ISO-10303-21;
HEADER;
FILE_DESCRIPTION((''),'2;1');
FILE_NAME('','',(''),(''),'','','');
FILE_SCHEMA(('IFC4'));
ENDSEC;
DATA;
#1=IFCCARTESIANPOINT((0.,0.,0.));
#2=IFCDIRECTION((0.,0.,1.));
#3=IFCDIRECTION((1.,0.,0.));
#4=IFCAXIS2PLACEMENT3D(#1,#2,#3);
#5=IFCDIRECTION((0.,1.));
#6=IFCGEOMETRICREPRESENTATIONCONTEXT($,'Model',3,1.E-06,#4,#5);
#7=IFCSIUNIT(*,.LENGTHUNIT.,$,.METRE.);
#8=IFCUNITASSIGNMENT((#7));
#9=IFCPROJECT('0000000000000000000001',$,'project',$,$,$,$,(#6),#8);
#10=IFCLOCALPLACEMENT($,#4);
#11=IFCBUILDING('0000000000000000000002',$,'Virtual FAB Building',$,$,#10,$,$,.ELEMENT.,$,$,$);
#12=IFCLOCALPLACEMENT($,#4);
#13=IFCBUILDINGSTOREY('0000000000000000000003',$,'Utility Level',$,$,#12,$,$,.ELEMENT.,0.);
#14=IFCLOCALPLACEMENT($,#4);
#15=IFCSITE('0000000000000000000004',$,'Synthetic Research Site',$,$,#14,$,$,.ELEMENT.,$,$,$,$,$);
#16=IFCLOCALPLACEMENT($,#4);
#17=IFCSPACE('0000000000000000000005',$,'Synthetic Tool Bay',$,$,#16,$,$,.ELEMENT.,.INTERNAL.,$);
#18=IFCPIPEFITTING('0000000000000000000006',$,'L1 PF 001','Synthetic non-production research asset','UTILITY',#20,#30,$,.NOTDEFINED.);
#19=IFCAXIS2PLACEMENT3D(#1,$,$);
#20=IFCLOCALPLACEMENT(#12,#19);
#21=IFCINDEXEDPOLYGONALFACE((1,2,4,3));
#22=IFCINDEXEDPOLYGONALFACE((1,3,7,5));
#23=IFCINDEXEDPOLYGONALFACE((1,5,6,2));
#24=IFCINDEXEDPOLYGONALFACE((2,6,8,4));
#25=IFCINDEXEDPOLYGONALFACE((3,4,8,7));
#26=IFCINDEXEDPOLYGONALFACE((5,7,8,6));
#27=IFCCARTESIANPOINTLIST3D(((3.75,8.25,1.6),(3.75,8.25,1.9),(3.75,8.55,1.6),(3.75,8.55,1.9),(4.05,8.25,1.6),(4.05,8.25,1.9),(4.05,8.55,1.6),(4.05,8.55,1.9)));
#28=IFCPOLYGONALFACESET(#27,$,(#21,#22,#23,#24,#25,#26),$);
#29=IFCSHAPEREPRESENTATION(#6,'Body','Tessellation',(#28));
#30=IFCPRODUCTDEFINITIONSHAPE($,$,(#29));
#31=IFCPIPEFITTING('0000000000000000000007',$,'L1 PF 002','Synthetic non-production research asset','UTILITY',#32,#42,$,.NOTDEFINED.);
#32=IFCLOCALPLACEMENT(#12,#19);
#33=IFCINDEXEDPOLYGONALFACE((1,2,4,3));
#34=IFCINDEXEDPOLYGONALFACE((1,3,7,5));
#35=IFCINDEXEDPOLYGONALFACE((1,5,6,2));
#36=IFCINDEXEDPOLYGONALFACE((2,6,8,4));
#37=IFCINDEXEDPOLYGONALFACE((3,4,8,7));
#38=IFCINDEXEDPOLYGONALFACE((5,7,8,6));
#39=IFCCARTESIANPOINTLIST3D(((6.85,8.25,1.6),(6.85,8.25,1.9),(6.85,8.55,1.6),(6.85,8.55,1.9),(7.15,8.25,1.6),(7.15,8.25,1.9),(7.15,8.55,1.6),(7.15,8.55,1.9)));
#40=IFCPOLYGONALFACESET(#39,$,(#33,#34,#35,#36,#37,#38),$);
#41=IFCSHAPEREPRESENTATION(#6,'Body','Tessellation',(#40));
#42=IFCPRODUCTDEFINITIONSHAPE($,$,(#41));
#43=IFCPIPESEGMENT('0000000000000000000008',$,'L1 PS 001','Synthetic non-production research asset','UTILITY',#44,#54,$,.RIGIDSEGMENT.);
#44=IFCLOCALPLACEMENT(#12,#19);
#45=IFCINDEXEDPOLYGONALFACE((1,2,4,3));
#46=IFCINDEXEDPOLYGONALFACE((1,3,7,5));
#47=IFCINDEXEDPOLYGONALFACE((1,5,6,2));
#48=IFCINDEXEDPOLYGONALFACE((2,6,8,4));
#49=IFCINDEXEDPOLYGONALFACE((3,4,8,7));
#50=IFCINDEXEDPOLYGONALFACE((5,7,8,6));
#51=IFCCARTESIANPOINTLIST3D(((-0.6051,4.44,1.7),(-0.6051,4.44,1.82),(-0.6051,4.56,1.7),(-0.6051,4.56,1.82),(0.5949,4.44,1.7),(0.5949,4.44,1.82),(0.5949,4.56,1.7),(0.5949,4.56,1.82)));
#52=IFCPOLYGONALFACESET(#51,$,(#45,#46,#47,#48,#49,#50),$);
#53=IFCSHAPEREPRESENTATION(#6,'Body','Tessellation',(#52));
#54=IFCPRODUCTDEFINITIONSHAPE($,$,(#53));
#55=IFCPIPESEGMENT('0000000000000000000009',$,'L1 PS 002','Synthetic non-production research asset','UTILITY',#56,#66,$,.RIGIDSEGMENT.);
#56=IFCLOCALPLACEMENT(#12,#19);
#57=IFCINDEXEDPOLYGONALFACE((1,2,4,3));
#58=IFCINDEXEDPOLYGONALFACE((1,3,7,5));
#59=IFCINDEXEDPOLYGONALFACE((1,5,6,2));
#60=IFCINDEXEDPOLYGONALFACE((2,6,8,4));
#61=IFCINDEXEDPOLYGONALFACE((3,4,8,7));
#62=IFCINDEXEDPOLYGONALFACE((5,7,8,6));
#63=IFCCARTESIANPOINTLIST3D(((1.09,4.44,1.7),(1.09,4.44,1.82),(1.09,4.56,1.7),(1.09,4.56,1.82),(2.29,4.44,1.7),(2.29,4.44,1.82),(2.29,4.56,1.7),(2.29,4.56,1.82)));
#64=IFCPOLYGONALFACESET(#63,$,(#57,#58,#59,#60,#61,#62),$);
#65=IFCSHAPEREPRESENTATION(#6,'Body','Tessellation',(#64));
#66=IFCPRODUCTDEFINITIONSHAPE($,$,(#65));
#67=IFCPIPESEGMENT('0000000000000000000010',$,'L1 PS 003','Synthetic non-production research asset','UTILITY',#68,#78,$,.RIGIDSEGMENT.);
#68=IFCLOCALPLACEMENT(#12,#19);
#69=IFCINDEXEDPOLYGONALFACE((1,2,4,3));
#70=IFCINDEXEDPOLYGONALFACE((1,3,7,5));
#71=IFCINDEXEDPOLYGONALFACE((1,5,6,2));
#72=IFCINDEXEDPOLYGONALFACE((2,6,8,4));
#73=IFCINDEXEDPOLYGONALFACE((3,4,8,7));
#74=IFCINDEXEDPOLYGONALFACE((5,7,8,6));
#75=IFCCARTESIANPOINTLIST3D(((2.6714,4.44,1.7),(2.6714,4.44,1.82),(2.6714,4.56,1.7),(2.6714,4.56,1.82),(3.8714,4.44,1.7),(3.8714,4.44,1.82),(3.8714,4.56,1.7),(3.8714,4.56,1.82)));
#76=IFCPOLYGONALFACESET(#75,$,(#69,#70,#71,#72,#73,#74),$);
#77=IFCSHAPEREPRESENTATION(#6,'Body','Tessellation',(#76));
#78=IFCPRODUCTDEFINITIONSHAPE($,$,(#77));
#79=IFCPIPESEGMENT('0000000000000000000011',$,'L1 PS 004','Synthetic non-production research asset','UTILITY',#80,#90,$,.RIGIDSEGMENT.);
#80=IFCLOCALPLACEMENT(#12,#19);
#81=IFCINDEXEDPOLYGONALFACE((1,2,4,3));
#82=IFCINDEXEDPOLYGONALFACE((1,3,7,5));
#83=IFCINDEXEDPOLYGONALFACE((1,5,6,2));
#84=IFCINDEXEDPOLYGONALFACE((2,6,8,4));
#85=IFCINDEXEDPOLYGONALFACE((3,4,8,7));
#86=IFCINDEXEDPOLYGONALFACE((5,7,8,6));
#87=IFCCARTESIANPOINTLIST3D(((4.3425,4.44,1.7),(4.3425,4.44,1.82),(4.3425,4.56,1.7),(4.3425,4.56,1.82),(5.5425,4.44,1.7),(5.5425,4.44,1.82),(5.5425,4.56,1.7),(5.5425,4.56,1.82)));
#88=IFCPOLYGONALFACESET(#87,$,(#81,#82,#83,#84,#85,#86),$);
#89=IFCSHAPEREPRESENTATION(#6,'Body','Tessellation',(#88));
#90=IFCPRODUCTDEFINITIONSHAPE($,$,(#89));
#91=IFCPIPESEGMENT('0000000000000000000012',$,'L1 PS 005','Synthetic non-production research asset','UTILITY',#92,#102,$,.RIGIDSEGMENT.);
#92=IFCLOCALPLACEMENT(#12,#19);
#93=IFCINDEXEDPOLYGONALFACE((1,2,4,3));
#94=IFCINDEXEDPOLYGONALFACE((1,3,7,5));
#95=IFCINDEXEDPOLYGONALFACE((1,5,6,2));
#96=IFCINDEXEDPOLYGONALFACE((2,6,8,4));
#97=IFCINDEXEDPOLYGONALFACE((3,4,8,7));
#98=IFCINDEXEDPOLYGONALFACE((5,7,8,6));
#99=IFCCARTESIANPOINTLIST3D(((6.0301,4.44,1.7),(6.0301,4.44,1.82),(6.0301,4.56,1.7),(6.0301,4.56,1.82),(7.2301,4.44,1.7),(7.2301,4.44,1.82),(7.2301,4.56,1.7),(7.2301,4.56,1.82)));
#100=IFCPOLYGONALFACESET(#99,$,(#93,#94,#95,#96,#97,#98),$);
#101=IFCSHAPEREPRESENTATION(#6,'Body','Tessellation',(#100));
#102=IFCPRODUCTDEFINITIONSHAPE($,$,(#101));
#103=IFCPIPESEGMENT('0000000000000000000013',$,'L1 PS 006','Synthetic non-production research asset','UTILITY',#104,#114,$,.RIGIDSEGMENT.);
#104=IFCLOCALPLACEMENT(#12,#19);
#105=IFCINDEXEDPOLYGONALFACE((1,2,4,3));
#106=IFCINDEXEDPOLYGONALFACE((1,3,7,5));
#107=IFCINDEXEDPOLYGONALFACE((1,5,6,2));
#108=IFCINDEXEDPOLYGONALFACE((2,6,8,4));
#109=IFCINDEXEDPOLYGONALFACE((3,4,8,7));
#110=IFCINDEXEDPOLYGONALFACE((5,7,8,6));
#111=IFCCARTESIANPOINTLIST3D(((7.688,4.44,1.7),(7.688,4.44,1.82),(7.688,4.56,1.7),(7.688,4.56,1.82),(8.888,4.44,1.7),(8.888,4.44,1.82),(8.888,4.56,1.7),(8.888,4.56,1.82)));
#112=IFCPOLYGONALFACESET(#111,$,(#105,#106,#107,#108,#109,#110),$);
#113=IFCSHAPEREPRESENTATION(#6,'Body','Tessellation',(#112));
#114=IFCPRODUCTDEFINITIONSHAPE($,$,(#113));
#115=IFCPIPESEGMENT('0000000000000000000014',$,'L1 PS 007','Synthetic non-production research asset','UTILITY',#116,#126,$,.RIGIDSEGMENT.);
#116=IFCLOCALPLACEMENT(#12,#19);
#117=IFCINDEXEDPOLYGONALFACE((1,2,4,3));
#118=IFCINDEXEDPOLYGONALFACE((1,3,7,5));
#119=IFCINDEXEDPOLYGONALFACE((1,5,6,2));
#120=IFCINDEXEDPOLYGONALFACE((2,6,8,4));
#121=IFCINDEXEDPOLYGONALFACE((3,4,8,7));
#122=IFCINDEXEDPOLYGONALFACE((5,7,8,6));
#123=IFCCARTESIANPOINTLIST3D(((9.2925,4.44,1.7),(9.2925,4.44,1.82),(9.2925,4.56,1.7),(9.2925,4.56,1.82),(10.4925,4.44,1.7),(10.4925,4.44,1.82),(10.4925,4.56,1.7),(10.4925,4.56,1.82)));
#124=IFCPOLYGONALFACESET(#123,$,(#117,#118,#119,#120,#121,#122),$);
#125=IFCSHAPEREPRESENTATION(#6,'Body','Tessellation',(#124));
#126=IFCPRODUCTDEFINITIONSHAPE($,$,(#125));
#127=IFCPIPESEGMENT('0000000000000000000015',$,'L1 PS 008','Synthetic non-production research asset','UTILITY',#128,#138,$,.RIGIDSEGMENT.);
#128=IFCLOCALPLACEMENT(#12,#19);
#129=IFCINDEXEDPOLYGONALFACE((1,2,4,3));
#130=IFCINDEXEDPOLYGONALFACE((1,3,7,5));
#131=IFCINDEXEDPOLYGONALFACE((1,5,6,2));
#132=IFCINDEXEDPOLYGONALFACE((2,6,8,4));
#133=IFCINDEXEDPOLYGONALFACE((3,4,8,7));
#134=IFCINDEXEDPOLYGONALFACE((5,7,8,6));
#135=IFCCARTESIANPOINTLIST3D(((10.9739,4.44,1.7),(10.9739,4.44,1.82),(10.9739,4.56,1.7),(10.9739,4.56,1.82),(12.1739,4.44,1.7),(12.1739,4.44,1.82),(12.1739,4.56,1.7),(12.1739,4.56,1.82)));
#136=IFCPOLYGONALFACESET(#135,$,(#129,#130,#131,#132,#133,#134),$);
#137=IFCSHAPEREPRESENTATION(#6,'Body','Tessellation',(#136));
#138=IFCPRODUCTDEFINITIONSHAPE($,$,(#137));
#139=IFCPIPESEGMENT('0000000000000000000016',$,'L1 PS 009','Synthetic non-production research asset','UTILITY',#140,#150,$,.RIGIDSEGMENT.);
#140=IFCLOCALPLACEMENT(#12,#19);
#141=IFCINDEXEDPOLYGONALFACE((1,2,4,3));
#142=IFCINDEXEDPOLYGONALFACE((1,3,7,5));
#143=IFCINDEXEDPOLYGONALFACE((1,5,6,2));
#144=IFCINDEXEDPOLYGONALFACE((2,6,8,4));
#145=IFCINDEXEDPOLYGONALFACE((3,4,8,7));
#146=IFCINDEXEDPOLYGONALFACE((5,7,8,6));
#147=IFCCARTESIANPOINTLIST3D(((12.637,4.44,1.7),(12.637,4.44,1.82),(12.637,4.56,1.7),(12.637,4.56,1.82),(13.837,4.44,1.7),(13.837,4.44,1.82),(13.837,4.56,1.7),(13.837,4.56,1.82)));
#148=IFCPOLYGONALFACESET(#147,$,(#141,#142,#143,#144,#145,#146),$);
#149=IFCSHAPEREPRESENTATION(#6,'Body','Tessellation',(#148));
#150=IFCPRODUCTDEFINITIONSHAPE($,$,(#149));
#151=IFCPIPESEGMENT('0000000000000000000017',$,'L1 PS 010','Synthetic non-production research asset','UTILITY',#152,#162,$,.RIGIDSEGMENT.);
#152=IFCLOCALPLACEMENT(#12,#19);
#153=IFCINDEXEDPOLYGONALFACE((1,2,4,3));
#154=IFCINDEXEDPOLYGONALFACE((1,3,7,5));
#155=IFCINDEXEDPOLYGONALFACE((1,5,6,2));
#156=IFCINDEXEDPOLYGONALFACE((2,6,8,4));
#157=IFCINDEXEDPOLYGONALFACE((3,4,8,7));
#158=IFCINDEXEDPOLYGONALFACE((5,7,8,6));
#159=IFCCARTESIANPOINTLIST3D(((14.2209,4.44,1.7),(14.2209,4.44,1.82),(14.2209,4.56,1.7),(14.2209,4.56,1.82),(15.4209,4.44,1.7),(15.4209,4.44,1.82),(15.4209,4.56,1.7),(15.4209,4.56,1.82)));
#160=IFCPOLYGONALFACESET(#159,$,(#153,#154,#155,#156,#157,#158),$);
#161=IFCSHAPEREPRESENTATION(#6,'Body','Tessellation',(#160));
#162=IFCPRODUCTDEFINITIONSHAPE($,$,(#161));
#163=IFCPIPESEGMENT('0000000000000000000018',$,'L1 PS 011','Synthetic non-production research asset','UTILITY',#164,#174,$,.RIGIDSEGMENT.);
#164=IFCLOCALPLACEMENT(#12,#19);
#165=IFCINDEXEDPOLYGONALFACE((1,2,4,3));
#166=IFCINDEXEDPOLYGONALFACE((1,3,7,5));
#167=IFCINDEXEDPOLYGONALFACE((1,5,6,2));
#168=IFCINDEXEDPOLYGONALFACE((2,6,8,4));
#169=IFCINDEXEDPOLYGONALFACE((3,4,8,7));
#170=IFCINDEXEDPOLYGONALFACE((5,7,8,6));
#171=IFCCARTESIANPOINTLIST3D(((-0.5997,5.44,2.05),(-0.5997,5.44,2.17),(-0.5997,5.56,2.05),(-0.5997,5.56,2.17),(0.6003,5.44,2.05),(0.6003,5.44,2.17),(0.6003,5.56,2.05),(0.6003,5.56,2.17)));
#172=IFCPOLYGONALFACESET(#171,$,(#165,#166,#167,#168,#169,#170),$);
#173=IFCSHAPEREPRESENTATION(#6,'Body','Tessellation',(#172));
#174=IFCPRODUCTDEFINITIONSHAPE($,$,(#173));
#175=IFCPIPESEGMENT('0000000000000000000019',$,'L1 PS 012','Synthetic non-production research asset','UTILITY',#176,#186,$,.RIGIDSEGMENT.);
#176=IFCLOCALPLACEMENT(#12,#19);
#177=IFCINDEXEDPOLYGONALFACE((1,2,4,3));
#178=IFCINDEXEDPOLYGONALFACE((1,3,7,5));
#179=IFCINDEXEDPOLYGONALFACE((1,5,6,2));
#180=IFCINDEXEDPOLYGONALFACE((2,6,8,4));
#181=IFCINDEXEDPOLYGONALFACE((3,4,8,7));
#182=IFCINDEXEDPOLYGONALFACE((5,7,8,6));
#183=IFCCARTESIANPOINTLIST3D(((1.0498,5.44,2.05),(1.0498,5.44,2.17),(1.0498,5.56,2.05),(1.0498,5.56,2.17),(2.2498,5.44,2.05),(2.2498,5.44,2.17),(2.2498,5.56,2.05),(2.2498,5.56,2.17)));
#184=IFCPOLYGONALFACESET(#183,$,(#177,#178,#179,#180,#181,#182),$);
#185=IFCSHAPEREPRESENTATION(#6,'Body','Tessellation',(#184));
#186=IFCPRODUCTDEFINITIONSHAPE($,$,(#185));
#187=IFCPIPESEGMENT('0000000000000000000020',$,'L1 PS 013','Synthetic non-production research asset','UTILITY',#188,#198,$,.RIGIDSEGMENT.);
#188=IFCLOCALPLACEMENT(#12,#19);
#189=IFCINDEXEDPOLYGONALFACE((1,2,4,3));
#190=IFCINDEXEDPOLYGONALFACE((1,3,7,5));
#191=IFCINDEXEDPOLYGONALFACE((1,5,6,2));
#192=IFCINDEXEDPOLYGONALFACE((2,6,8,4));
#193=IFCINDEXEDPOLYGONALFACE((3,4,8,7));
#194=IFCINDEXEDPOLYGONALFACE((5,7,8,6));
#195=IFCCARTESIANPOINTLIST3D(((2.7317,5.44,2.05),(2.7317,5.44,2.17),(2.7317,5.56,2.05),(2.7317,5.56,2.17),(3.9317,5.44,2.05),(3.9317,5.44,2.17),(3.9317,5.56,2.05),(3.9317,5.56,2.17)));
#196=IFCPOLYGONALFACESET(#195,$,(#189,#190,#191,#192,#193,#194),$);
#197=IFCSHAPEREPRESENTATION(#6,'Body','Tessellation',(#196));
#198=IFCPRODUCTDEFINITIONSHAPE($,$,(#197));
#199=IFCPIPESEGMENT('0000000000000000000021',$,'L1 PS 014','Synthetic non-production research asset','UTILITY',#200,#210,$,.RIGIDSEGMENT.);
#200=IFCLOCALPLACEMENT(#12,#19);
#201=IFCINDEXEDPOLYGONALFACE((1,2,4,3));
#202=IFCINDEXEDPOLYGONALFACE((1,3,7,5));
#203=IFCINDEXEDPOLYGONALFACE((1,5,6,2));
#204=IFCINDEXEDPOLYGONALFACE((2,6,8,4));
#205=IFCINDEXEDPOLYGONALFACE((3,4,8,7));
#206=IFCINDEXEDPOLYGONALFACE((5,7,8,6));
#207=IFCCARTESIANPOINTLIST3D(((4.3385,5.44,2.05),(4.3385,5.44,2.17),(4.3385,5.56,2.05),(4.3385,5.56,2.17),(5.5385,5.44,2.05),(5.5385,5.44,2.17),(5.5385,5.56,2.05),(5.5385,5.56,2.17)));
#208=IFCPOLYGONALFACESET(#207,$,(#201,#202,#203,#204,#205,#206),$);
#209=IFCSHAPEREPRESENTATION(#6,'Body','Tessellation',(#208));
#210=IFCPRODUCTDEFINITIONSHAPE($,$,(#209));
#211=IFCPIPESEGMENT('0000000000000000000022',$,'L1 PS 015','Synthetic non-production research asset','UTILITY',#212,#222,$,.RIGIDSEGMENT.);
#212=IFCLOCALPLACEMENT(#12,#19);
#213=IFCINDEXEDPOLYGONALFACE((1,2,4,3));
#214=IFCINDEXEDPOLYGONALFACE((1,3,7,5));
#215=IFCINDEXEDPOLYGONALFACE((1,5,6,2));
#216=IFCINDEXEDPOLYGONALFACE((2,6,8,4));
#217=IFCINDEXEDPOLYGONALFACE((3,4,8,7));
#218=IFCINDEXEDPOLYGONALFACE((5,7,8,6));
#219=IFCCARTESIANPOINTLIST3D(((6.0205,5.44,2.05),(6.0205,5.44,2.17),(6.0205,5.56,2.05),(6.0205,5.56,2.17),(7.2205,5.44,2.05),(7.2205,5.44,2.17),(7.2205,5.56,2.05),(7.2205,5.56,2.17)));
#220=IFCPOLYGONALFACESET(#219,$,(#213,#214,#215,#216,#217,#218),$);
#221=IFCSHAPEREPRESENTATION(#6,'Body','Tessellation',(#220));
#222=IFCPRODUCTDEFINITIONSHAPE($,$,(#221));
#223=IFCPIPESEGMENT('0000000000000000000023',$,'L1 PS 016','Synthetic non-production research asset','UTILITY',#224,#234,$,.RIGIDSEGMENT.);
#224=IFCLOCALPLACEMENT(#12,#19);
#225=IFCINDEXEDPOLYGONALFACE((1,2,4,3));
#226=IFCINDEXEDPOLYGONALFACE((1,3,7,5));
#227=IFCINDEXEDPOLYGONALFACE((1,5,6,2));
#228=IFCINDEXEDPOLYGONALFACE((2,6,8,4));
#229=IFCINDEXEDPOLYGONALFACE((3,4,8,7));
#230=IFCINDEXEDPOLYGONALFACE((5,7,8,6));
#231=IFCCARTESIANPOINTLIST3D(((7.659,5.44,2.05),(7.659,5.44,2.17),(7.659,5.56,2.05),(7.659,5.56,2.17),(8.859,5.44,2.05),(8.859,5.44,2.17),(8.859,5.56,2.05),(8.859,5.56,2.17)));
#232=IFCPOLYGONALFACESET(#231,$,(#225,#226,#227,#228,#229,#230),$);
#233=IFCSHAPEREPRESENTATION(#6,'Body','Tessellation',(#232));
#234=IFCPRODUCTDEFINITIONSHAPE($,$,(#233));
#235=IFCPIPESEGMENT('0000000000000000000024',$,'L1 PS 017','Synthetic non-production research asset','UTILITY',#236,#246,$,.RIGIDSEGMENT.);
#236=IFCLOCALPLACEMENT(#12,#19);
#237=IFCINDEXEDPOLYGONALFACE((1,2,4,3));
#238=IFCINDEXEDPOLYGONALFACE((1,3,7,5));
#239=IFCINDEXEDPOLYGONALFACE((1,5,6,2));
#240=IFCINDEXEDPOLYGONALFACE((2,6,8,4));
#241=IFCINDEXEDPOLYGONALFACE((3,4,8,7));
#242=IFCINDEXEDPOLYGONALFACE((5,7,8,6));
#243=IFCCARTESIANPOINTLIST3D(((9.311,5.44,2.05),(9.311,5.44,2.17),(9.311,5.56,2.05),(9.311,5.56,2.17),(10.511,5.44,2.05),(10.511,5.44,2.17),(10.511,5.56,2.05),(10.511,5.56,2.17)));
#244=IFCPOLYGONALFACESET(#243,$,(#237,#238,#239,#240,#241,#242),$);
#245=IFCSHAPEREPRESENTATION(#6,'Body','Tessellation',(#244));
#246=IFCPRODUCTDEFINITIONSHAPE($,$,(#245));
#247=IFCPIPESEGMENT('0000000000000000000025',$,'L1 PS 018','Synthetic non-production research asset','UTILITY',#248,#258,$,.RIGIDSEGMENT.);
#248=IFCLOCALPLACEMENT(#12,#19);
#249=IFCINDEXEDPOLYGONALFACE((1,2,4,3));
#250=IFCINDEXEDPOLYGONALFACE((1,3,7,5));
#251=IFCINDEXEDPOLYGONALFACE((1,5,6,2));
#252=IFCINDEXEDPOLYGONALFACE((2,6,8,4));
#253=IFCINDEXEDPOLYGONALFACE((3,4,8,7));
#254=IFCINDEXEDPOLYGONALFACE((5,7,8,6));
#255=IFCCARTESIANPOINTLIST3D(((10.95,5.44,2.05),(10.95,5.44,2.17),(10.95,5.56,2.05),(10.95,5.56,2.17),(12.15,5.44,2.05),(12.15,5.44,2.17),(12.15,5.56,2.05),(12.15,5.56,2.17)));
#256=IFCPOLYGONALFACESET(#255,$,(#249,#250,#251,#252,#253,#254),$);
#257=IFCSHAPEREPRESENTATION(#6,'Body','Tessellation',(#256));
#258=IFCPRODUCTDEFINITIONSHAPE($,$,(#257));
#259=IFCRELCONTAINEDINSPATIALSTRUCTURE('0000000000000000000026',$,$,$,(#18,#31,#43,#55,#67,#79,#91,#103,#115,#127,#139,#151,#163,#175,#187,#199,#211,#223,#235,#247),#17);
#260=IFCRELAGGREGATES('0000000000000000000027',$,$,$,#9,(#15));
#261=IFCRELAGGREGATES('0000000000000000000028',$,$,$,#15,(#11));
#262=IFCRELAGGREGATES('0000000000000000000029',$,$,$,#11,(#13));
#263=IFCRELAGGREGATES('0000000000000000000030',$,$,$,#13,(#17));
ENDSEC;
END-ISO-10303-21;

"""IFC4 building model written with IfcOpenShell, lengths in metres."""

from ifc_helpers import new_model, si_unit, direction, frame, origin_with_axes, origin_2d_with_axis, place, context, project, spatial, rectangle, extrude, element, save


model = new_model("IFC4")

# Units and contexts
model_context = context("Model", 3, precision=1e-06, world=origin_with_axes(), true_north=direction((0.0, 1.0)))
ifc_project = project(units=[si_unit("LENGTHUNIT", "METRE")], contexts=[model_context])

# Site, building, storey, space
site_placement = place(None, origin_with_axes())
site = spatial("IfcSite", under=ifc_project, at=site_placement, Name="Synthetic Research Site", CompositionType="ELEMENT")
building_placement = place(None, origin_with_axes())
building = spatial("IfcBuilding", under=site, at=building_placement, Name="Virtual FAB Building", CompositionType="ELEMENT")
storey_placement = place(None, origin_with_axes())
storey = spatial("IfcBuildingStorey", under=building, at=storey_placement, Name="Utility Level", CompositionType="ELEMENT", Elevation=0.0)
space_placement = place(None, origin_with_axes())
space = spatial("IfcSpace", under=storey, at=space_placement, Name="Synthetic Tool Bay", CompositionType="ELEMENT", PredefinedType="INTERNAL")

# Pipe fittings
for number, where, z_axis, x_axis, name in (
    (1, (3.9, 8.4, 1.6), (0.0, 0.0, 1.0), (1.0, 0.0, 0.0), "L1 PF 001"),
    (2, (7.0, 8.4, 1.6), (0.0, 0.0, 1.0), (1.0, 0.0, 0.0), "L1 PF 002"),
):
    element("IfcPipeFitting", number, at=place(None, frame(where, z_axis=z_axis, x_axis=x_axis)), inside=space, Name=name, Description="Synthetic non-production research asset", ObjectType="UTILITY", PredefinedType="NOTDEFINED", context=model_context, shape_type="SweptSolid", body=[
        extrude(rectangle(XDim=0.3, YDim=0.3, at=origin_2d_with_axis()), origin_with_axes(), (0.0, 0.0, 1.0), 0.3),
    ])

# Pipe segments
for number, where, z_axis, x_axis, name in (
    (3, (-0.0051, 4.5, 1.7), (0.0, 0.0, 1.0), (1.0, 0.0, 0.0), "L1 PS 001"),
    (4, (1.69, 4.5, 1.7), (0.0, 0.0, 1.0), (1.0, 0.0, 0.0), "L1 PS 002"),
    (5, (3.2714, 4.5, 1.7), (0.0, 0.0, 1.0), (1.0, 0.0, 0.0), "L1 PS 003"),
    (6, (4.9425, 4.5, 1.7), (0.0, 0.0, 1.0), (1.0, 0.0, 0.0), "L1 PS 004"),
    (7, (6.6301, 4.5, 1.7), (0.0, 0.0, 1.0), (1.0, 0.0, 0.0), "L1 PS 005"),
    (8, (8.288, 4.5, 1.7), (0.0, 0.0, 1.0), (1.0, 0.0, 0.0), "L1 PS 006"),
    (9, (9.8925, 4.5, 1.7), (0.0, 0.0, 1.0), (1.0, 0.0, 0.0), "L1 PS 007"),
    (10, (11.5739, 4.5, 1.7), (0.0, 0.0, 1.0), (1.0, 0.0, 0.0), "L1 PS 008"),
    (11, (13.237, 4.5, 1.7), (0.0, 0.0, 1.0), (1.0, 0.0, 0.0), "L1 PS 009"),
    (12, (14.8209, 4.5, 1.7), (0.0, 0.0, 1.0), (1.0, 0.0, 0.0), "L1 PS 010"),
    (13, (0.0003, 5.5, 2.05), (0.0, 0.0, 1.0), (1.0, 0.0, 0.0), "L1 PS 011"),
    (14, (1.6498, 5.5, 2.05), (0.0, 0.0, 1.0), (1.0, 0.0, 0.0), "L1 PS 012"),
    (15, (3.3317, 5.5, 2.05), (0.0, 0.0, 1.0), (1.0, 0.0, 0.0), "L1 PS 013"),
    (16, (4.9385, 5.5, 2.05), (0.0, 0.0, 1.0), (1.0, 0.0, 0.0), "L1 PS 014"),
    (17, (6.6205, 5.5, 2.05), (0.0, 0.0, 1.0), (1.0, 0.0, 0.0), "L1 PS 015"),
    (18, (8.259, 5.5, 2.05), (0.0, 0.0, 1.0), (1.0, 0.0, 0.0), "L1 PS 016"),
    (19, (9.911, 5.5, 2.05), (0.0, 0.0, 1.0), (1.0, 0.0, 0.0), "L1 PS 017"),
    (20, (11.55, 5.5, 2.05), (0.0, 0.0, 1.0), (1.0, 0.0, 0.0), "L1 PS 018"),
):
    element("IfcPipeSegment", number, at=place(None, frame(where, z_axis=z_axis, x_axis=x_axis)), inside=space, Name=name, Description="Synthetic non-production research asset", ObjectType="UTILITY", PredefinedType="RIGIDSEGMENT", context=model_context, shape_type="SweptSolid", body=[
        extrude(rectangle(XDim=1.2, YDim=0.12, at=origin_2d_with_axis()), origin_with_axes(), (0.0, 0.0, 1.0), 0.12),
    ])

save(model, "model.ifc")
